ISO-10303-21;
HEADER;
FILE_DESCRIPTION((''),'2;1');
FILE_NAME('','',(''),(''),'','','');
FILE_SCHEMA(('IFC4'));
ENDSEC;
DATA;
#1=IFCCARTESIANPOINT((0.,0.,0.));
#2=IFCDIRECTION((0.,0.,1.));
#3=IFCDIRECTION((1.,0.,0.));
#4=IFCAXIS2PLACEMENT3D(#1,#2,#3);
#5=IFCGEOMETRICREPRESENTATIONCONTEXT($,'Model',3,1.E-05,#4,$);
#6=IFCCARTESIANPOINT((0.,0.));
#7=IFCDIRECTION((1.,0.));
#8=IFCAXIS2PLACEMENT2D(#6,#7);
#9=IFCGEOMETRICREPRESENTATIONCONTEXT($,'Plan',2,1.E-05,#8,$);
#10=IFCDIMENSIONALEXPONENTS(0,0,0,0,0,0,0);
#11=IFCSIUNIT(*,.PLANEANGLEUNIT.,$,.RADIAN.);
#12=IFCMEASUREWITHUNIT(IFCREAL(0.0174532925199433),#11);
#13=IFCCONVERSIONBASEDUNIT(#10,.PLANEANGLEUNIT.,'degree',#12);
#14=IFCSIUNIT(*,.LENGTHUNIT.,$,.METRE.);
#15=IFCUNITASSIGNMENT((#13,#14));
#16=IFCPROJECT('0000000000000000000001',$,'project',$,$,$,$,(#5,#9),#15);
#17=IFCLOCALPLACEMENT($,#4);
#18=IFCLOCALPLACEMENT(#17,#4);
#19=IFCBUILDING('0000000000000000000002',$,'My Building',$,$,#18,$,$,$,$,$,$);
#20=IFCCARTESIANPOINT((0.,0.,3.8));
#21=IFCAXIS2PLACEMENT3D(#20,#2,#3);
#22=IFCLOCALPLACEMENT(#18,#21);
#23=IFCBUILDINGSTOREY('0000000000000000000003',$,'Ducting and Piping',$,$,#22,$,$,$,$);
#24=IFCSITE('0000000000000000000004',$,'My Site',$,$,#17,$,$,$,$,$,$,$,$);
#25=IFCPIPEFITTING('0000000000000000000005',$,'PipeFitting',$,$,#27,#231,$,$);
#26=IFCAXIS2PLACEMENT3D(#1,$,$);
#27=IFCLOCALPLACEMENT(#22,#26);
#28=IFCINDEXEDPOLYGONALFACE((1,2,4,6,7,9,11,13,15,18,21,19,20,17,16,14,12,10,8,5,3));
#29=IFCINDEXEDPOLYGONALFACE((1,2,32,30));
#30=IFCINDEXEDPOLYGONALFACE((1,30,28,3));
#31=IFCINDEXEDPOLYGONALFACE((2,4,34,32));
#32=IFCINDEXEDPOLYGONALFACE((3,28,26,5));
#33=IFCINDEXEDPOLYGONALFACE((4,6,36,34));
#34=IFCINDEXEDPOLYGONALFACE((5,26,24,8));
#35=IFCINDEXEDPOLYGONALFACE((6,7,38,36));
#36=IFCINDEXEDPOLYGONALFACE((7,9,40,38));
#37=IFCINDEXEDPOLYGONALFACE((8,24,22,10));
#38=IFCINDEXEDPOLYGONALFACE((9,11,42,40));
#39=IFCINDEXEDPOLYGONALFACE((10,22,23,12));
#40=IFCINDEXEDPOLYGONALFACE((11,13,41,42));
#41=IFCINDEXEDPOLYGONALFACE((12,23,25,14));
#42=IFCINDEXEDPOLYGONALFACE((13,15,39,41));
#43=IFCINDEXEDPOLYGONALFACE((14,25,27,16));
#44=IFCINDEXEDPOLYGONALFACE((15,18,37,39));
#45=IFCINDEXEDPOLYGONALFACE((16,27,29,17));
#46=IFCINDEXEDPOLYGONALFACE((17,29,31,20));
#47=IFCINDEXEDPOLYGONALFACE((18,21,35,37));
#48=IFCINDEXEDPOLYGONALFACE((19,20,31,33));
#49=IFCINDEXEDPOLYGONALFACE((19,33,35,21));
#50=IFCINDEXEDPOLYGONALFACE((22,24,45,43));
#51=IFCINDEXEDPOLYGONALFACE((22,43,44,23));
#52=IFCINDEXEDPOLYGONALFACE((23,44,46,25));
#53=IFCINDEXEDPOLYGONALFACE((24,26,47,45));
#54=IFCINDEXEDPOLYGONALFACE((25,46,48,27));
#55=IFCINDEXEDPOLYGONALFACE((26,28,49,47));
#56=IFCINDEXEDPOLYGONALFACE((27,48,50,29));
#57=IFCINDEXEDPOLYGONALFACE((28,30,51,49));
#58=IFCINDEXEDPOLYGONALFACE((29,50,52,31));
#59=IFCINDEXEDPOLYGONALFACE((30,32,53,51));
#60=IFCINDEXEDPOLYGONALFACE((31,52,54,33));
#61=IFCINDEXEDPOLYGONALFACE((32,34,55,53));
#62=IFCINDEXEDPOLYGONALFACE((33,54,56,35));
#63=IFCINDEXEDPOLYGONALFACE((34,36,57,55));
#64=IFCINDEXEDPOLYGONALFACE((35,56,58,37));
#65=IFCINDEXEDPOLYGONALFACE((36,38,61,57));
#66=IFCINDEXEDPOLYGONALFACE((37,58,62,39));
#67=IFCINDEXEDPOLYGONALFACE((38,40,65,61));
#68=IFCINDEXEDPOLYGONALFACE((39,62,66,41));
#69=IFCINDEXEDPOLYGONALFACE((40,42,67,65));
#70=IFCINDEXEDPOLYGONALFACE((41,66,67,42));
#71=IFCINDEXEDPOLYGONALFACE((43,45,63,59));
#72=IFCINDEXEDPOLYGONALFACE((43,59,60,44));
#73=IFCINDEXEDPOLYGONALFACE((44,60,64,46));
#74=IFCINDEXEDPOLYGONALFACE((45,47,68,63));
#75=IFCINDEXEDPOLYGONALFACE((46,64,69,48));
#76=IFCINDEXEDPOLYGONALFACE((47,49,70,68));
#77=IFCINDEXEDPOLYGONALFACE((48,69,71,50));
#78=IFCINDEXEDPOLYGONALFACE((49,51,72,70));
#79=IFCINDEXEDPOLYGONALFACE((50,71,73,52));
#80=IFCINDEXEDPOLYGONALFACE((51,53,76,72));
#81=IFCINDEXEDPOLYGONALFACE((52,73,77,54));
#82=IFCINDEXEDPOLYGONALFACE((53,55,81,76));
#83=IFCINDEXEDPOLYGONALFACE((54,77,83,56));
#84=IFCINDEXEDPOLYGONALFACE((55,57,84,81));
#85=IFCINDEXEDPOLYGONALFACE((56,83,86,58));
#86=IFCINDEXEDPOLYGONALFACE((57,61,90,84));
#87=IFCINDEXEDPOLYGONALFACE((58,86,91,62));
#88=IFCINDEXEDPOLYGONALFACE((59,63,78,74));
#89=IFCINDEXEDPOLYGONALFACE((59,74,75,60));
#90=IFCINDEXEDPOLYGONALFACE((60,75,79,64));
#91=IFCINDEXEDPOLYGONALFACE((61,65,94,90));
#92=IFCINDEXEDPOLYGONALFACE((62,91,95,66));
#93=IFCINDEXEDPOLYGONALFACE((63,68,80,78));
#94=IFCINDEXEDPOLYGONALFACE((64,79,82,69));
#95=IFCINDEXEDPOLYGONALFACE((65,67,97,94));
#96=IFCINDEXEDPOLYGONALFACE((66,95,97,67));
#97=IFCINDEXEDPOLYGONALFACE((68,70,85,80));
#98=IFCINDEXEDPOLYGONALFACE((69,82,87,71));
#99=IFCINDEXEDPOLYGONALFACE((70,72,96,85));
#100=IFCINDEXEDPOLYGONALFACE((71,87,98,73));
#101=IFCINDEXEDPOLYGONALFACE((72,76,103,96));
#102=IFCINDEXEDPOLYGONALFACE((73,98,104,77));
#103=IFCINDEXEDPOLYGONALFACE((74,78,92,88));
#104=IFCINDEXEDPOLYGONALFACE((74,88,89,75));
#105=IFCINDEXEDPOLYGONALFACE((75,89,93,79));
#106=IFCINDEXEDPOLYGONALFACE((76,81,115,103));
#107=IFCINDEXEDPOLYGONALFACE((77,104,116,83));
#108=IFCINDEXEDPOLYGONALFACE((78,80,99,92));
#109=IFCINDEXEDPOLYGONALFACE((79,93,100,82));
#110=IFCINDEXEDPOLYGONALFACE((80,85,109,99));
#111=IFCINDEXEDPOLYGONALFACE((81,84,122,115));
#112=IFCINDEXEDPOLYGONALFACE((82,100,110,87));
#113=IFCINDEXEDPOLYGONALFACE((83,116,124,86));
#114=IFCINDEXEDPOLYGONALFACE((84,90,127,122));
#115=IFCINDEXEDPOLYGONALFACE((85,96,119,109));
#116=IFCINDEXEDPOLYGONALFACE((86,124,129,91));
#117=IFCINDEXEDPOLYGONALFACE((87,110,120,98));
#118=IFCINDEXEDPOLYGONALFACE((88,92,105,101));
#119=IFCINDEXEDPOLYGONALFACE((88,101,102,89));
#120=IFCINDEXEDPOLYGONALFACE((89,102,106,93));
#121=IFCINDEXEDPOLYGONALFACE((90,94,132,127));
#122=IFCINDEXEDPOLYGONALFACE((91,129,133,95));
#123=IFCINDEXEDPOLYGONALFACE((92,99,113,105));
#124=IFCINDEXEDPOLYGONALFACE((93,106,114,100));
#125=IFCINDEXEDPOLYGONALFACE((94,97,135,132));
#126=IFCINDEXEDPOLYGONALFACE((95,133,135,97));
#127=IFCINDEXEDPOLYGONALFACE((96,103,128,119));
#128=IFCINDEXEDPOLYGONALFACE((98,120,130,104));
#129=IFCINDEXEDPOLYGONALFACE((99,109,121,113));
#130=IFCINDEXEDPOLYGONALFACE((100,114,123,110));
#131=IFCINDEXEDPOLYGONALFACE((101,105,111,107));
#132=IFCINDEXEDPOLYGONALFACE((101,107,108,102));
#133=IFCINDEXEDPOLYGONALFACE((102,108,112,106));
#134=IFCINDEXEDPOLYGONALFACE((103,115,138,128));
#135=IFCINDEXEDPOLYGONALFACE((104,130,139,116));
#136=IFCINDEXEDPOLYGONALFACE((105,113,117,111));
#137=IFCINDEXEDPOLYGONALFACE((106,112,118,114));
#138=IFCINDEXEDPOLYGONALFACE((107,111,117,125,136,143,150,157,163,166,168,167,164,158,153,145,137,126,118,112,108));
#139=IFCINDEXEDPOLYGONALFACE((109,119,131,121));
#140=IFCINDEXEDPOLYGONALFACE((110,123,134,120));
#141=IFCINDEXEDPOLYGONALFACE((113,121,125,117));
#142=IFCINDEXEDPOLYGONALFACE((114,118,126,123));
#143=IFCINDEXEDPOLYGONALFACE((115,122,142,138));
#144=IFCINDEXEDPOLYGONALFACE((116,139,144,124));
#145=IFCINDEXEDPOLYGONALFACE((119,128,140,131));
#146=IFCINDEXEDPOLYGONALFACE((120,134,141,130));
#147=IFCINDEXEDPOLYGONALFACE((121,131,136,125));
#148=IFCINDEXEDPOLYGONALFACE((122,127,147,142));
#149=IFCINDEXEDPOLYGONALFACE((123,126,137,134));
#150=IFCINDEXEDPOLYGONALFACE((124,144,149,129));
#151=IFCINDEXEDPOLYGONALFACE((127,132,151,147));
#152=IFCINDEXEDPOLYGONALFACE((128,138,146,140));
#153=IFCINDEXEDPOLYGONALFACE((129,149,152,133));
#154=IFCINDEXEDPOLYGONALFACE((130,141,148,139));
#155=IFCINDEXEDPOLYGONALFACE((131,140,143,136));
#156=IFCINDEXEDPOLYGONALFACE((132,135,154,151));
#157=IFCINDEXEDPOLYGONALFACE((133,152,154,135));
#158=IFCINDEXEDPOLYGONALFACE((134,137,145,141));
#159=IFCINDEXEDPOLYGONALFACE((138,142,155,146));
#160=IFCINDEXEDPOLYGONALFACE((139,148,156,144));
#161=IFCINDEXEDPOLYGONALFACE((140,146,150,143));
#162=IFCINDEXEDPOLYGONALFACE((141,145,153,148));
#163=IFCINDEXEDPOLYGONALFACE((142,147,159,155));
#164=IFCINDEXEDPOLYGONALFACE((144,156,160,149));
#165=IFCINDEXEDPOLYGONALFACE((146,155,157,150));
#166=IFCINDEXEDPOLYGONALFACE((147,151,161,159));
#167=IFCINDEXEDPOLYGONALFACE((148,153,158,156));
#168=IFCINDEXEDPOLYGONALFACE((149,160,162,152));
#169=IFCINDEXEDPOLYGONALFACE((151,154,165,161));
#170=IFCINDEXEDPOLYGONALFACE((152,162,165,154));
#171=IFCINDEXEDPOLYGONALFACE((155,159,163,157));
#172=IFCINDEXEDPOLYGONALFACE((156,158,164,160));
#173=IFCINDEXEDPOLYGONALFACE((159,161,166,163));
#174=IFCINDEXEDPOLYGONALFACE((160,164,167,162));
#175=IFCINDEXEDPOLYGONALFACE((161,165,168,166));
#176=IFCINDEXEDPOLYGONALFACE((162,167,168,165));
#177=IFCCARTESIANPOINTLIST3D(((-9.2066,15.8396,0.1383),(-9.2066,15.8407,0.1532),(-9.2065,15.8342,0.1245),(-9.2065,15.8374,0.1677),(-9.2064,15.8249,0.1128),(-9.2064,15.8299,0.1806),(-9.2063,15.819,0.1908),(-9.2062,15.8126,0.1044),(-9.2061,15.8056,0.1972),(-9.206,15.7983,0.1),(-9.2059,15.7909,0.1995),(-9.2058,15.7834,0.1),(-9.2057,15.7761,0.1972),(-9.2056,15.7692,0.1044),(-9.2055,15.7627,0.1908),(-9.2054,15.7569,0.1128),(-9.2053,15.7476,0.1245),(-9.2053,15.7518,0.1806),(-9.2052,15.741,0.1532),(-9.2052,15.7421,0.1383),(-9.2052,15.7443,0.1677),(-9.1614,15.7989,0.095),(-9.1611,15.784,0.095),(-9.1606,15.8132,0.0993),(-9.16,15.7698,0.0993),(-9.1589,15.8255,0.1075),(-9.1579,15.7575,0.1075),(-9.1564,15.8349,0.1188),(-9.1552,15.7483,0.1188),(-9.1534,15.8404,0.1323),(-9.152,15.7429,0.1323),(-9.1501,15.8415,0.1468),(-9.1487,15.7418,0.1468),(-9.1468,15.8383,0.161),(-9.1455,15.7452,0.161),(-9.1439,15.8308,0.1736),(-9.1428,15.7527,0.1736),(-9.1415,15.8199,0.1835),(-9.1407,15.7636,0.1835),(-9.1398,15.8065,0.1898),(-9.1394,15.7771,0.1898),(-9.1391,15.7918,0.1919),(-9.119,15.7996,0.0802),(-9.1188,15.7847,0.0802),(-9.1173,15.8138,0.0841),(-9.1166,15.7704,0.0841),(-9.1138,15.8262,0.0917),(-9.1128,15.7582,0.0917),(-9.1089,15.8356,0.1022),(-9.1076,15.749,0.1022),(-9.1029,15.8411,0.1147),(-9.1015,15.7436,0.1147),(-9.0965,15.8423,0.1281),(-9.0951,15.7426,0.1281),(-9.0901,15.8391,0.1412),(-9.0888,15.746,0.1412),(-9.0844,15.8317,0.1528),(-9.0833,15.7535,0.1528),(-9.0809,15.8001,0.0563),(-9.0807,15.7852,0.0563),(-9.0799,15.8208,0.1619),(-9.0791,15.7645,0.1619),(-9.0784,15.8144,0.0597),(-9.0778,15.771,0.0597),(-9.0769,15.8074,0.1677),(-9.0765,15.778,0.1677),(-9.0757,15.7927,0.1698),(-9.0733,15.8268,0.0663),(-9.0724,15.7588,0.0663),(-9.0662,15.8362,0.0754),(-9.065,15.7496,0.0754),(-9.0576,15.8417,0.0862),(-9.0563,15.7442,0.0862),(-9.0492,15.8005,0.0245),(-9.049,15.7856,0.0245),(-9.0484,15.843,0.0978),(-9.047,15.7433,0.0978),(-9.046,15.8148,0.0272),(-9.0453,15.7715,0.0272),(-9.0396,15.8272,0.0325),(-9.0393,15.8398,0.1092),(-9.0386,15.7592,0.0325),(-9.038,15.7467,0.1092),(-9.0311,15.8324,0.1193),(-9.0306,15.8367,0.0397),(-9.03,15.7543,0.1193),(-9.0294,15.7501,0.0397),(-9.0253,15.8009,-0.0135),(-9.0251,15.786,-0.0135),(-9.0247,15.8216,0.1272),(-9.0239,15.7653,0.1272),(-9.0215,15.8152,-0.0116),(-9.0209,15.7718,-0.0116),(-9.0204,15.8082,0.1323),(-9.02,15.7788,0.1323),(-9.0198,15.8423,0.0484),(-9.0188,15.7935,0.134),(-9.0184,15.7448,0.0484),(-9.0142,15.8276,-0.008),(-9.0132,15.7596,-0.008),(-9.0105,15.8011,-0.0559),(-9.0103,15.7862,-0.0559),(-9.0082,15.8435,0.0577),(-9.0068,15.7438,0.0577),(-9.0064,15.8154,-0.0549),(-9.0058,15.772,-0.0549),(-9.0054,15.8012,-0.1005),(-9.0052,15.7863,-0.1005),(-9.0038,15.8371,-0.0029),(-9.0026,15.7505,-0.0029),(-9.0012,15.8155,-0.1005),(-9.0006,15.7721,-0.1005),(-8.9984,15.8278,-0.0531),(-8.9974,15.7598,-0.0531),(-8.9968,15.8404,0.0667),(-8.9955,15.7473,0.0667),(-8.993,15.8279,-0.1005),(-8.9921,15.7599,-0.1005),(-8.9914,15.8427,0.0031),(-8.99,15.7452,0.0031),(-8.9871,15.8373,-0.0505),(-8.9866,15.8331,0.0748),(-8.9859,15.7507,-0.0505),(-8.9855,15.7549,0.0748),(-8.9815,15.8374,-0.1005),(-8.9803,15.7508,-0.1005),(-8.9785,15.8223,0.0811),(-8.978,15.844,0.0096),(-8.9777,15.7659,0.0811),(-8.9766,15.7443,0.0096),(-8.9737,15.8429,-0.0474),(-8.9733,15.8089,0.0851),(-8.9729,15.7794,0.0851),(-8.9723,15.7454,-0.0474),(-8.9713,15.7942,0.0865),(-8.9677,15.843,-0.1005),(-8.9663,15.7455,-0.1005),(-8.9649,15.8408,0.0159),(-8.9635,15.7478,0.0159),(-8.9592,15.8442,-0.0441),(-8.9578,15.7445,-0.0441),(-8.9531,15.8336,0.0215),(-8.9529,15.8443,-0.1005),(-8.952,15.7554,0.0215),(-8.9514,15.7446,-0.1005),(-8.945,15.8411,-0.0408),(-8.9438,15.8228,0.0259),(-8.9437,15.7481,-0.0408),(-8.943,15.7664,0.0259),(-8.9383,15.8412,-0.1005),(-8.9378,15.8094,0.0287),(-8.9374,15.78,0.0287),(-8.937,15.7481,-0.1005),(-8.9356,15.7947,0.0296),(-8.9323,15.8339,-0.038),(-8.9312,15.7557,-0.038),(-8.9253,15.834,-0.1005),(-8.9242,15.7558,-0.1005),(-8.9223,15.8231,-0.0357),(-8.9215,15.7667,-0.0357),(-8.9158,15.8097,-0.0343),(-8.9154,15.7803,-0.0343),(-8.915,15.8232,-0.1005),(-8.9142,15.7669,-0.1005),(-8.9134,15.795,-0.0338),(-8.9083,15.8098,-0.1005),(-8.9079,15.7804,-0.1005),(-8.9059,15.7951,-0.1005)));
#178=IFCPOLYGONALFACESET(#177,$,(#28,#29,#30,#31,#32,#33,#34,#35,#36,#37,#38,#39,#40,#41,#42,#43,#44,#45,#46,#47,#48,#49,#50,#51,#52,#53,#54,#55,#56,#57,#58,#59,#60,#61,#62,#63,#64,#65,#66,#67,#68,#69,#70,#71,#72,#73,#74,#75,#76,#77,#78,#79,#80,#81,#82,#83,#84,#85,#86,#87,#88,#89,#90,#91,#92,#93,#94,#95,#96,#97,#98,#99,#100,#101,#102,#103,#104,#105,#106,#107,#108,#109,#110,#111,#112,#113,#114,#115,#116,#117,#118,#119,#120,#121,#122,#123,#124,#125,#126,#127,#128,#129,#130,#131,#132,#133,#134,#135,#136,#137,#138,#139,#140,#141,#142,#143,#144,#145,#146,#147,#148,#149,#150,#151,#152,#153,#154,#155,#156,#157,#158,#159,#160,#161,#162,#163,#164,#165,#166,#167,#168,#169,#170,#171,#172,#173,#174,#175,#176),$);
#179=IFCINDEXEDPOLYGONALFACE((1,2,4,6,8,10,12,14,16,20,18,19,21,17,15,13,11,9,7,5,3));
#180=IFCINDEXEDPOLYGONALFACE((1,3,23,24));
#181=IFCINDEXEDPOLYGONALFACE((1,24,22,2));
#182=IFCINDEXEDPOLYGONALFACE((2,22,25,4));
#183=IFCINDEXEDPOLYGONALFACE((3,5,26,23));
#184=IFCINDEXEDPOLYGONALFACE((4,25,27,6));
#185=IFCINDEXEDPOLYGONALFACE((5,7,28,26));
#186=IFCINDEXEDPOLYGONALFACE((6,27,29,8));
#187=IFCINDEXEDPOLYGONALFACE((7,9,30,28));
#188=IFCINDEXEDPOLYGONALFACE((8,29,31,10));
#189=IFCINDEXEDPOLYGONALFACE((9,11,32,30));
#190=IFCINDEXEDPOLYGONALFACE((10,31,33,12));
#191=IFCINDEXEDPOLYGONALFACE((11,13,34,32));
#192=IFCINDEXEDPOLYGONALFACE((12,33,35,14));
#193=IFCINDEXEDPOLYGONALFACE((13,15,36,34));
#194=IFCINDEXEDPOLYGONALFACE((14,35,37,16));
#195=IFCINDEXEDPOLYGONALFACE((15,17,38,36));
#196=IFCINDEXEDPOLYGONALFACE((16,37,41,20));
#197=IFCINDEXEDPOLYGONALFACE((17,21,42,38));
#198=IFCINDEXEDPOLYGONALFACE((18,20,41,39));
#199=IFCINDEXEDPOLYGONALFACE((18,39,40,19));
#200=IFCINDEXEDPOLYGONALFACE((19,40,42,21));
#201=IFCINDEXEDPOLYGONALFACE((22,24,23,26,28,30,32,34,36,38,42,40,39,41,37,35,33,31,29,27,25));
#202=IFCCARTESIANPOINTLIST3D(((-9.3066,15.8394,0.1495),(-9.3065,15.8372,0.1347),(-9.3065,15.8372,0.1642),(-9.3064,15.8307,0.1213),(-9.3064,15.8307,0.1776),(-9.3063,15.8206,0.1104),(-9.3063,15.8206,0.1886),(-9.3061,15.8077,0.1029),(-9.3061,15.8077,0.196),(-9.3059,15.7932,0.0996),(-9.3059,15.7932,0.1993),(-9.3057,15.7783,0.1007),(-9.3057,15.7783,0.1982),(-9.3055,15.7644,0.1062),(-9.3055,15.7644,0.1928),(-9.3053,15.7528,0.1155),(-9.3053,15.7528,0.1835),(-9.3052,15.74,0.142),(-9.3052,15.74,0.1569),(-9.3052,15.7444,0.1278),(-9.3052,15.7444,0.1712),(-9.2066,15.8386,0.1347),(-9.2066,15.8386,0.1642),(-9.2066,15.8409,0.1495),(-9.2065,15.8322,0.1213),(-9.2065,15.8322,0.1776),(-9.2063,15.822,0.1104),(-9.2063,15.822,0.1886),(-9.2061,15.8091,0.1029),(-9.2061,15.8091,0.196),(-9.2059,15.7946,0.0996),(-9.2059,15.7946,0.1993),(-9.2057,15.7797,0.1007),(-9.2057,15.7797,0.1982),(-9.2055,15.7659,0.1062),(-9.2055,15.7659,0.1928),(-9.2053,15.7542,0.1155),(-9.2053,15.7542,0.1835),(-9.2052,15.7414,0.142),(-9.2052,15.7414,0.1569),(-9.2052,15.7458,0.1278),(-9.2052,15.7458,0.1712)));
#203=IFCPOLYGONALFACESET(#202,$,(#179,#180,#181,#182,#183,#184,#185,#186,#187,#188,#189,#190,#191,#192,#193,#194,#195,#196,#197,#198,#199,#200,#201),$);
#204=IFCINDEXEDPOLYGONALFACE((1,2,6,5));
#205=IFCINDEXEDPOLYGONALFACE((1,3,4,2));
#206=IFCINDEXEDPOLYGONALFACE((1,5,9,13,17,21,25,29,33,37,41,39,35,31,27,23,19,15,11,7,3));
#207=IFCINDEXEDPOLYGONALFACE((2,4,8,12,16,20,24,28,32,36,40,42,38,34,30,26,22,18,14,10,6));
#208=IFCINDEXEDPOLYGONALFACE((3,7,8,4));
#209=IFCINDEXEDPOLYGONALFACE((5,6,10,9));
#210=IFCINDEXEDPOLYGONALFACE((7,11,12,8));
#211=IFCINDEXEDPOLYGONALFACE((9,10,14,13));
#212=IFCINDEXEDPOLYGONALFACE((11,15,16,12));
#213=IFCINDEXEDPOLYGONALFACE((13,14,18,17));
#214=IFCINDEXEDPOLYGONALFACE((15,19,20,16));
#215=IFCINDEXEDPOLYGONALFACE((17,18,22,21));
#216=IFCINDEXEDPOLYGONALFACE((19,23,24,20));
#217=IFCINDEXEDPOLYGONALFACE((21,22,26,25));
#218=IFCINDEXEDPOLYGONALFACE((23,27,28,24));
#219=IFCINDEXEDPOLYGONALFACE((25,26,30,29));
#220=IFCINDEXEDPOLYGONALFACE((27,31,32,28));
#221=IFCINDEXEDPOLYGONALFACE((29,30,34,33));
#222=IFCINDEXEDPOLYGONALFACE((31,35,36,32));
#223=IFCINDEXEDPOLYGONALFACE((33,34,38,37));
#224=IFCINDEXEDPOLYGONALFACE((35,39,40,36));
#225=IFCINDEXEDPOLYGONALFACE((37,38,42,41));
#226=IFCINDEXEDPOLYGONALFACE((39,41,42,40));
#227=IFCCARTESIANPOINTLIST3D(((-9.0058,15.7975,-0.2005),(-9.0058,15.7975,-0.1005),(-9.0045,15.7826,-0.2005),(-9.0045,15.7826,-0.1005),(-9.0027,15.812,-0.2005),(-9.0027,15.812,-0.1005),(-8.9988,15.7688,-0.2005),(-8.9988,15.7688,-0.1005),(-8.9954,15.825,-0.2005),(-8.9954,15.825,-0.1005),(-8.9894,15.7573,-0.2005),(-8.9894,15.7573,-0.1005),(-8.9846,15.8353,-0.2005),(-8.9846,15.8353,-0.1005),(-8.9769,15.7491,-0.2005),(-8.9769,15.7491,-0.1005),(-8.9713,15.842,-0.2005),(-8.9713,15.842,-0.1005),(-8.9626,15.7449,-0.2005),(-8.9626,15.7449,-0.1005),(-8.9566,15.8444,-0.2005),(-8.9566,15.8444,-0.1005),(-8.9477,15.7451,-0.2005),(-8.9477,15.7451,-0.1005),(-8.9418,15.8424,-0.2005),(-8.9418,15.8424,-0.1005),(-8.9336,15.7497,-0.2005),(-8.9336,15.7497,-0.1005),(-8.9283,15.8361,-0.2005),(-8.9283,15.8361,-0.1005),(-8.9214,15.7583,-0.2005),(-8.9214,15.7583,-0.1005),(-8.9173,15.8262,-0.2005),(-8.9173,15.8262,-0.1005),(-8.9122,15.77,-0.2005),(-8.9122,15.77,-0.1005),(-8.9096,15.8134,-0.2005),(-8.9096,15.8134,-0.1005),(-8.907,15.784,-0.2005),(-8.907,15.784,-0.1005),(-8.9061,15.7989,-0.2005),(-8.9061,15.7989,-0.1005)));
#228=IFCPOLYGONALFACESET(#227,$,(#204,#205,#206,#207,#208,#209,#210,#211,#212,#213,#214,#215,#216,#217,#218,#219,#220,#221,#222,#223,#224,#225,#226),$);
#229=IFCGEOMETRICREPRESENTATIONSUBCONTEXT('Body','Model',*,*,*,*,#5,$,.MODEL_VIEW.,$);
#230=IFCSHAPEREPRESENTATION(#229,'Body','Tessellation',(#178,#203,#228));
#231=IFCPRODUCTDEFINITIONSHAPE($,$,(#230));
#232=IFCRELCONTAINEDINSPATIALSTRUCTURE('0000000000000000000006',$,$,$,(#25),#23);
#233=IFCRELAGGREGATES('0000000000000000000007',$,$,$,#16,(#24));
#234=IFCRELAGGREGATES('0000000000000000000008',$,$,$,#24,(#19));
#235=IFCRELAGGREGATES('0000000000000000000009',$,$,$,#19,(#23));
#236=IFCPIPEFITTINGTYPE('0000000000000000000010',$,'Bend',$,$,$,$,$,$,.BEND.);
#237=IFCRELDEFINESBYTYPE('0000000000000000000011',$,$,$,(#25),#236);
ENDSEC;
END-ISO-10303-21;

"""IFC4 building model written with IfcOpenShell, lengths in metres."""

from ifc_helpers import new_model, entity, si_unit, converted_unit, frame, origin_with_axes, origin_2d_with_axis, place, context, subcontext, project, spatial, circle, extrude, source, transform, mapped, type_object, type_shapes, element, save


model = new_model("IFC4")

# Units and contexts
model_context = context("Model", 3, precision=1e-05, world=origin_with_axes())
plan_context = context("Plan", 2, precision=1e-05, world=origin_2d_with_axis())
body_context = subcontext(model_context, "Body", "Model", "MODEL_VIEW")
ifc_project = project(units=[converted_unit("PLANEANGLEUNIT", "degree", entity("IfcReal", 0.0174532925199433), si_unit("PLANEANGLEUNIT", "RADIAN"), dimensions=[0, 0, 0, 0, 0, 0, 0]), si_unit("LENGTHUNIT", "METRE")], contexts=[model_context, plan_context])

# Site, building, storey
site_placement = place(None, origin_with_axes())
site = spatial("IfcSite", under=ifc_project, at=site_placement, Name="My Site")
building_placement = place(site_placement, origin_with_axes())
building = spatial("IfcBuilding", under=site, at=building_placement, Name="My Building")
storey_placement = place(building_placement, frame((0.0, 0.0, 3.8), z_axis=(0.0, 0.0, 1.0), x_axis=(1.0, 0.0, 0.0)))
storey = spatial("IfcBuildingStorey", under=building, at=storey_placement, Name="Ducting and Piping")

# Pipe fitting
pipe_fitting_type = type_object("IfcPipeFittingType", Name="Bend", PredefinedType="BEND")
shared_shape = source(origin_with_axes(), body_context, "Body", "SolidModel", [
    entity("IfcSweptDiskSolid", entity("IfcIndexedPolyCurve", entity("IfcCartesianPointList3D", [[0.0, 0.0, 0.1], [0.0, -0.0732, 0.2768], [0.0, -0.25, 0.35]]), [entity("IfcArcIndex", [1, 2, 3])]), 0.05),
    extrude(circle(Radius=0.05), origin_with_axes(), (0.0, 0.0, 1.0), 0.1),
    extrude(circle(Radius=0.05), frame((0.0, -0.25, 0.35), z_axis=(0.0, -1.0, 0.0), x_axis=(1.0, 0.0, 0.0)), (0.0, 0.0, 1.0), 0.1),
])
type_shapes(pipe_fitting_type, [shared_shape])
for number, where, z_axis, x_axis, name in (
    (1, (-9.3059, 15.7894, 0.1495), (0.999898, 0.014266, 0.0), (-0.014266, 0.999898, 0.0), "PipeFitting"),
):
    element("IfcPipeFitting", number, at=place(storey_placement, frame(where, z_axis=z_axis, x_axis=x_axis)), inside=storey, type_object=pipe_fitting_type, Name=name, context=body_context, shape_type="MappedRepresentation", body=[
        mapped(shared_shape, transform((0.0, 0.0, 0.0), x_axis=(1.0, 0.0, 0.0), y_axis=(0.0, 1.0, 0.0), z_axis=(0.0, 0.0, 1.0), scale=1.0)),
    ])

save(model, "model.ifc")
